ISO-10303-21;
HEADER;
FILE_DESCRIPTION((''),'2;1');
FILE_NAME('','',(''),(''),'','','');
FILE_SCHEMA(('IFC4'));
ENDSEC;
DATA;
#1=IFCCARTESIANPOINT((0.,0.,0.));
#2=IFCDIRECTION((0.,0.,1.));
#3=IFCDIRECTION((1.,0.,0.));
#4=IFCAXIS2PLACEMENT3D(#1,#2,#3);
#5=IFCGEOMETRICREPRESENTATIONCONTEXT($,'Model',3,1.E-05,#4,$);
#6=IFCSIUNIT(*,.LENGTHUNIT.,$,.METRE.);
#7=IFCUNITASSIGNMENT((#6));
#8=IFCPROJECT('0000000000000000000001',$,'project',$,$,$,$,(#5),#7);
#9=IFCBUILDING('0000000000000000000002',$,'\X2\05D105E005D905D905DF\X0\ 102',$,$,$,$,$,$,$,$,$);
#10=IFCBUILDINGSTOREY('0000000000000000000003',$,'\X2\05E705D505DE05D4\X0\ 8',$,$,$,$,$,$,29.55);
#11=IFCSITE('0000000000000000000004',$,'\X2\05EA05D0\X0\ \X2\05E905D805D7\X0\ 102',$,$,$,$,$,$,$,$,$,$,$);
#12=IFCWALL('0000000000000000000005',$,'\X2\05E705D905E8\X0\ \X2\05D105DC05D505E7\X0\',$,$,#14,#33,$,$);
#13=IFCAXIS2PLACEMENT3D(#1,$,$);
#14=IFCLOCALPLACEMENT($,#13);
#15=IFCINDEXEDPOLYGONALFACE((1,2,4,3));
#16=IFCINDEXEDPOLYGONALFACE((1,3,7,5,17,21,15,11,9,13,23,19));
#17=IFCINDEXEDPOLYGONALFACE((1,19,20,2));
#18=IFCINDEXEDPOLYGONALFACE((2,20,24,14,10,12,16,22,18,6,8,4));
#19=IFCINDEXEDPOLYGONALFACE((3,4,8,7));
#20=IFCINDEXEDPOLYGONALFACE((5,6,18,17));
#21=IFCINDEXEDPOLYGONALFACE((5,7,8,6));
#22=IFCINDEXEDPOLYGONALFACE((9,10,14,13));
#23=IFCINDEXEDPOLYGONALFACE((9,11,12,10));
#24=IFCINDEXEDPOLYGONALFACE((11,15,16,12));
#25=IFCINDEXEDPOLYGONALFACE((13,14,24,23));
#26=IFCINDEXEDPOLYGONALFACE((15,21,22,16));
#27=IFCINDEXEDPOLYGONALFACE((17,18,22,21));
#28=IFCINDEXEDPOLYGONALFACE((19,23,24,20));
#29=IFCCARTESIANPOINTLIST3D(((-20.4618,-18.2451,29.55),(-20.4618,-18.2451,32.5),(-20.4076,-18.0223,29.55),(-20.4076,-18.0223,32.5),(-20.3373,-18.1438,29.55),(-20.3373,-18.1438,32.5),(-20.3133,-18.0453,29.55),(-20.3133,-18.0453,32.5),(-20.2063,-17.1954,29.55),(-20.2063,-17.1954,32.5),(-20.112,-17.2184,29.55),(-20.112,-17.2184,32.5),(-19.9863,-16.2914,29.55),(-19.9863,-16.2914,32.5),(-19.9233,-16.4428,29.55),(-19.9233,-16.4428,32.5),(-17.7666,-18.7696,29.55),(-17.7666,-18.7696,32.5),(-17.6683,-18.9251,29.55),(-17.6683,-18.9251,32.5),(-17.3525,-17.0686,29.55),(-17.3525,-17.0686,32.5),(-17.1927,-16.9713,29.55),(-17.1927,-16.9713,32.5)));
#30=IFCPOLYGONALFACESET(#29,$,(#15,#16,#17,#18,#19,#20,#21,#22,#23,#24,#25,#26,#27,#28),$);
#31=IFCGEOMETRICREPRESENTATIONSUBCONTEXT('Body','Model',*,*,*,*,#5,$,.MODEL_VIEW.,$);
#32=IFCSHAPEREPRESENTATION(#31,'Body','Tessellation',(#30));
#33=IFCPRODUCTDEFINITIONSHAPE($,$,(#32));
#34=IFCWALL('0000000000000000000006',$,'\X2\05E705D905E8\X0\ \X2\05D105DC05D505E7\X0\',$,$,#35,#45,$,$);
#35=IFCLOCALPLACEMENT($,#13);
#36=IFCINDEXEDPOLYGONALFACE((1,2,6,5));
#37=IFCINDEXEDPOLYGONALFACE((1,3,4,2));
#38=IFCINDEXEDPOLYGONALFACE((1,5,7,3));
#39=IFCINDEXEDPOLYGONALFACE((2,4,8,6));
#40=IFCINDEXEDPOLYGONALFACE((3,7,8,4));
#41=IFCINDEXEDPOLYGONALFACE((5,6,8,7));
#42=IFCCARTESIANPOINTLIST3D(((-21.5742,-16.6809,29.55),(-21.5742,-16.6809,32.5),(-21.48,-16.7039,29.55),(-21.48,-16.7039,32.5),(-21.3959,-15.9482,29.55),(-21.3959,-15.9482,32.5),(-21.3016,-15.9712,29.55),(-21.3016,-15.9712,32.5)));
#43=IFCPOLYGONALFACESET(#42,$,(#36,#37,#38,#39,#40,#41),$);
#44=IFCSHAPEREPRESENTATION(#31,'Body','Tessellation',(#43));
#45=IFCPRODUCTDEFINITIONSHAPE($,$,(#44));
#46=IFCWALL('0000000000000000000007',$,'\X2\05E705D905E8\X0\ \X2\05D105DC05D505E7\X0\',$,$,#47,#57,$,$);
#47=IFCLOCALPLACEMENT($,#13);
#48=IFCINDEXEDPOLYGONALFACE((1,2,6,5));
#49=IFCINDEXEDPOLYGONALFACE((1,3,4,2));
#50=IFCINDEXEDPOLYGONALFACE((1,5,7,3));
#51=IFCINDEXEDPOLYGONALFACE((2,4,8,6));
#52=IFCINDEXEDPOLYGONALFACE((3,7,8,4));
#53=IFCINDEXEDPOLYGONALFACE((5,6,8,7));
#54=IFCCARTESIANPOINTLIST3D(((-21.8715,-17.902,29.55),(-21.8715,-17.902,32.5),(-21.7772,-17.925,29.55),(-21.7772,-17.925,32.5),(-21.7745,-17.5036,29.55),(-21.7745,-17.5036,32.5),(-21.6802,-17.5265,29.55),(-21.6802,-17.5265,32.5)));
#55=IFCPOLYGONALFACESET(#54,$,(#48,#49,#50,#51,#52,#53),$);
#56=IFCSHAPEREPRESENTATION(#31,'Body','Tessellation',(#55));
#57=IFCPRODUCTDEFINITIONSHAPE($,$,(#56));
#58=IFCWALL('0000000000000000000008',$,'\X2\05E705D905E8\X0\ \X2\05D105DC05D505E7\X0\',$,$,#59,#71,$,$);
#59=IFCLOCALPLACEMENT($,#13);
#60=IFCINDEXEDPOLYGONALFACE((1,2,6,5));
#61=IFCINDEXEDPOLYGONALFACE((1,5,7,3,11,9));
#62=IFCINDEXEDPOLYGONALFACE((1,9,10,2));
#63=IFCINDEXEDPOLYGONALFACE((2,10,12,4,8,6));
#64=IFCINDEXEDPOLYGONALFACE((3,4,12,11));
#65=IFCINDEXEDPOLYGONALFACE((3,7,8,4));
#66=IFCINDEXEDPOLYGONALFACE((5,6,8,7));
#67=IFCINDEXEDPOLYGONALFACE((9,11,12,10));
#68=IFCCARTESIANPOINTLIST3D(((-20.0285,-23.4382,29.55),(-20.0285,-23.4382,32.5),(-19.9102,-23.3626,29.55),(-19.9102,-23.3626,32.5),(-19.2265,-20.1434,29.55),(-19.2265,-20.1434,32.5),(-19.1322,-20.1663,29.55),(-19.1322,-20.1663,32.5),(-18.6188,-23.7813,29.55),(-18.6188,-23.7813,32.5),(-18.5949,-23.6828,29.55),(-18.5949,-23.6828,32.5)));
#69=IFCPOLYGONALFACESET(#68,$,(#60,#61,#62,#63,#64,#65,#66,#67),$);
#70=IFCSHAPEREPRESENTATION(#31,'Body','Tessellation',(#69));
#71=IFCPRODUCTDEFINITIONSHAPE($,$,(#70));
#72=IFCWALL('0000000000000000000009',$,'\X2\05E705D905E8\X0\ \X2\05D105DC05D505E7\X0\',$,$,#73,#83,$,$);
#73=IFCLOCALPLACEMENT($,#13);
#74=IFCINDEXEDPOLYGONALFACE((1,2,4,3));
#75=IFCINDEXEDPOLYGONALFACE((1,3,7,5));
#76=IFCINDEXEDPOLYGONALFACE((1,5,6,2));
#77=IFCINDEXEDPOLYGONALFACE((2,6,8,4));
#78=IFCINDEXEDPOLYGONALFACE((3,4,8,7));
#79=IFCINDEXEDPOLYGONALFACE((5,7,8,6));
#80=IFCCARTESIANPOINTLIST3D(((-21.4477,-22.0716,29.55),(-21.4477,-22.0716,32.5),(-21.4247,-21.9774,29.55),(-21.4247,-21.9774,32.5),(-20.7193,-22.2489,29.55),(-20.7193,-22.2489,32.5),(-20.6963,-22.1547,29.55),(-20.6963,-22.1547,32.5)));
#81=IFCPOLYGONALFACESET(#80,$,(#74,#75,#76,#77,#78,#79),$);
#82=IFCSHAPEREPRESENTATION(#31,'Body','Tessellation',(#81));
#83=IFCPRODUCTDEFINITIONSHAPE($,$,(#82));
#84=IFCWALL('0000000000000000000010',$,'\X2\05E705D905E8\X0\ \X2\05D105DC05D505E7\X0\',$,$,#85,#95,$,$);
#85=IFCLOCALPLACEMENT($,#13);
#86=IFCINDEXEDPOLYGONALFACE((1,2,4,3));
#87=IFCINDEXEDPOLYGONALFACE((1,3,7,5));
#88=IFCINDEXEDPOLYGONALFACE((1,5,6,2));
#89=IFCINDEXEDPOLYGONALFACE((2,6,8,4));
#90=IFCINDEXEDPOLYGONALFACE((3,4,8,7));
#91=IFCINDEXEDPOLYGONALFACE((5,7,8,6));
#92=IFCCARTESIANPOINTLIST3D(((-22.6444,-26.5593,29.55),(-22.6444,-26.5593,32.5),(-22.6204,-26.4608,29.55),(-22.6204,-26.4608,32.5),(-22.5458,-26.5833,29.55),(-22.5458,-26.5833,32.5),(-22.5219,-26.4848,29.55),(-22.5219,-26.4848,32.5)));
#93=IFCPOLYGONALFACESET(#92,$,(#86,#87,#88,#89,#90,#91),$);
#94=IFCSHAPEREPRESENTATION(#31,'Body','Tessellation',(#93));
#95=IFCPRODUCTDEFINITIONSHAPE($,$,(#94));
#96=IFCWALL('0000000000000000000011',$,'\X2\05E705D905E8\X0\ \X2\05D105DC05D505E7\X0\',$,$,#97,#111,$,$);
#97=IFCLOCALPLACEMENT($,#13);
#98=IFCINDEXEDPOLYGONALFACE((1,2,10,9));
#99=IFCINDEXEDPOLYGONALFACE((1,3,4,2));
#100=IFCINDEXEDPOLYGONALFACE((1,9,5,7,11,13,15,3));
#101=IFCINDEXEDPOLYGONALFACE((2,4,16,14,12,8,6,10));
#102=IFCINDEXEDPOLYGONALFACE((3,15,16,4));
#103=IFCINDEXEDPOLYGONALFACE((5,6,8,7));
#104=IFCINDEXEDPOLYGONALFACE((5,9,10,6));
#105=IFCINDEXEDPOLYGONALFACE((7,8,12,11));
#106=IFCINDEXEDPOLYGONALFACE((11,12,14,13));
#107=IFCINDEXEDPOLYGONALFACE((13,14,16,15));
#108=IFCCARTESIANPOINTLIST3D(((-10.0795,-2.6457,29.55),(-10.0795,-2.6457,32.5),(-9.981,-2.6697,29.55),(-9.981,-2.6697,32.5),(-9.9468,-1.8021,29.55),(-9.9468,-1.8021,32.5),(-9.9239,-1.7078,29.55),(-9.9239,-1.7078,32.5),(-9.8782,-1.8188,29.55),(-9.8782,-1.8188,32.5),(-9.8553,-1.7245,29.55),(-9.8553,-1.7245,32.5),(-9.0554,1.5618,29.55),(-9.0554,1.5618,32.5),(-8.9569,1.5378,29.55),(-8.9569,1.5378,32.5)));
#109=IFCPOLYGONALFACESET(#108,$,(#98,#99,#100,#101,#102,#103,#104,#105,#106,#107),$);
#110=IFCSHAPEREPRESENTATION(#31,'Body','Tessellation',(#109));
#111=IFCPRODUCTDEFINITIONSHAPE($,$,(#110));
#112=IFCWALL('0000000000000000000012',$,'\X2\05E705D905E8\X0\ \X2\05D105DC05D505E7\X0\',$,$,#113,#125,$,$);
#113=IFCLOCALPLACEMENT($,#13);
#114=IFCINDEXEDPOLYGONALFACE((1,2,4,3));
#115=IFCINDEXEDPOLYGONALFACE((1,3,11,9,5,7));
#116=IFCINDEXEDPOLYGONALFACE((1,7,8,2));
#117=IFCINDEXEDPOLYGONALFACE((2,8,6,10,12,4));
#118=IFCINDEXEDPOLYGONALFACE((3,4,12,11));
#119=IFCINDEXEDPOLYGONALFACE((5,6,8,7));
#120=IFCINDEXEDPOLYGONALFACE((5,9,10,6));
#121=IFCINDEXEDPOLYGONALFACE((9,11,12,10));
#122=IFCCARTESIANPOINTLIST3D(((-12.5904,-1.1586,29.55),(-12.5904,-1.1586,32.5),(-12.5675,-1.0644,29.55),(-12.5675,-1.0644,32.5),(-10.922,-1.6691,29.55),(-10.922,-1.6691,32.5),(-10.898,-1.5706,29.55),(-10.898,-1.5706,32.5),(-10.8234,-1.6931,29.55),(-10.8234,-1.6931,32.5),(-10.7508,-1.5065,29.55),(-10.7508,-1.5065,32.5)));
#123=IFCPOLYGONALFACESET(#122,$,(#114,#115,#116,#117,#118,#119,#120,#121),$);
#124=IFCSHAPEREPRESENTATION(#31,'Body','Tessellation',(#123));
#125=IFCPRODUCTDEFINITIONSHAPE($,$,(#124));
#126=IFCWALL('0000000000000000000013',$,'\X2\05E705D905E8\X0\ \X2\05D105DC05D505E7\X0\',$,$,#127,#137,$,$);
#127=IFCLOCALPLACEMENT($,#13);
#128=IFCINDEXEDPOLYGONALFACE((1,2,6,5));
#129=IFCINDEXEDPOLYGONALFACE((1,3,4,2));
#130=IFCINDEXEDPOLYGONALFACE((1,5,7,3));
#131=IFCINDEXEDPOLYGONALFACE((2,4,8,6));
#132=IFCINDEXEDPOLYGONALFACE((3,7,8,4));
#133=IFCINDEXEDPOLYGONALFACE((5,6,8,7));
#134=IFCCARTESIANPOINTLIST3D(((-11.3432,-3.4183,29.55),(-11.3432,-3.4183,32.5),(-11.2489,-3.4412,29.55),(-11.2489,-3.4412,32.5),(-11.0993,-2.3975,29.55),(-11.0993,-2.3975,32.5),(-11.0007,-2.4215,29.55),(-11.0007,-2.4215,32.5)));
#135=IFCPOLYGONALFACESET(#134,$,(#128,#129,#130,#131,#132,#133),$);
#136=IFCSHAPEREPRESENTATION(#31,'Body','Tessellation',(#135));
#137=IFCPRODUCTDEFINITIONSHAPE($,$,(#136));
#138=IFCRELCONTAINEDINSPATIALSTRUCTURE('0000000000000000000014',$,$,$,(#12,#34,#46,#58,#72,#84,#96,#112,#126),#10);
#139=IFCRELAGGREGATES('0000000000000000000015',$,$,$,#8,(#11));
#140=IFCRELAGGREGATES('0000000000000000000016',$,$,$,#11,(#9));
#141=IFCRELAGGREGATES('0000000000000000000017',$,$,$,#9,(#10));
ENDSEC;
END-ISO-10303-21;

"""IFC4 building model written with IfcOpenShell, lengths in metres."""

from ifc_helpers import new_model, si_unit, frame, origin_with_axes, context, subcontext, project, spatial, polyline, outline, extrude, element, save


model = new_model("IFC4")

# Units and contexts
model_context = context("Model", 3, precision=1e-05, world=origin_with_axes())
body_context = subcontext(model_context, "Body", "Model", "MODEL_VIEW")
ifc_project = project(units=[si_unit("LENGTHUNIT", "METRE")], contexts=[model_context])

# Site, building, storey
site = spatial("IfcSite", under=ifc_project, Name="תא שטח 102")
building = spatial("IfcBuilding", under=site, Name="בניין 102")
storey = spatial("IfcBuildingStorey", under=building, Name="קומה 8", Elevation=29.55)

# Walls
element("IfcWall", 1, inside=storey, Name="קיר בלוק", context=body_context, shape_type="SweptSolid", body=[
    extrude(outline(polyline([(-19.9233, -16.4428), (-17.3525, -17.0686), (-17.7666, -18.7696), (-20.3373, -18.1438), (-20.3133, -18.0453), (-20.4076, -18.0223), (-20.4618, -18.2451), (-17.6683, -18.9251), (-17.1927, -16.9713), (-19.9863, -16.2914), (-20.2063, -17.1954), (-20.112, -17.2184), (-19.9233, -16.4428)])), frame((0.0, 0.0, 29.55)), (0.0, 0.0, 1.0), 2.95),
])
element("IfcWall", 2, inside=storey, Name="קיר בלוק", context=body_context, shape_type="SweptSolid", body=[
    extrude(outline(polyline([(-21.3959, -15.9482), (-21.5742, -16.6809), (-21.48, -16.7039), (-21.3016, -15.9712), (-21.3959, -15.9482)])), frame((0.0, 0.0, 29.55)), (0.0, 0.0, 1.0), 2.95),
])
element("IfcWall", 3, inside=storey, Name="קיר בלוק", context=body_context, shape_type="SweptSolid", body=[
    extrude(outline(polyline([(-21.8715, -17.902), (-21.7772, -17.925), (-21.6802, -17.5265), (-21.7745, -17.5036), (-21.8715, -17.902)])), frame((0.0, 0.0, 29.55)), (0.0, 0.0, 1.0), 2.95),
])
element("IfcWall", 4, inside=storey, Name="קיר בלוק", context=body_context, shape_type="SweptSolid", body=[
    extrude(outline(polyline([(-18.5949, -23.6828), (-19.9102, -23.3626), (-19.1322, -20.1663), (-19.2265, -20.1434), (-20.0285, -23.4382), (-18.6188, -23.7813), (-18.5949, -23.6828)])), frame((0.0, 0.0, 29.55)), (0.0, 0.0, 1.0), 2.95),
])
element("IfcWall", 5, inside=storey, Name="קיר בלוק", context=body_context, shape_type="SweptSolid", body=[
    extrude(outline(polyline([(-21.4477, -22.0716), (-20.7193, -22.2489), (-20.6963, -22.1547), (-21.4247, -21.9774), (-21.4477, -22.0716)])), frame((0.0, 0.0, 29.55)), (0.0, 0.0, 1.0), 2.95),
])
element("IfcWall", 6, inside=storey, Name="קיר בלוק", context=body_context, shape_type="SweptSolid", body=[
    extrude(outline(polyline([(-22.6444, -26.5593), (-22.5458, -26.5833), (-22.5219, -26.4848), (-22.6204, -26.4608), (-22.6444, -26.5593)])), frame((0.0, 0.0, 29.55)), (0.0, 0.0, 1.0), 2.95),
])
element("IfcWall", 7, inside=storey, Name="קיר בלוק", context=body_context, shape_type="SweptSolid", body=[
    extrude(outline(polyline([(-10.0795, -2.6457), (-9.981, -2.6697), (-8.9569, 1.5378), (-9.0554, 1.5618), (-9.8553, -1.7245), (-9.9239, -1.7078), (-9.9468, -1.8021), (-9.8782, -1.8188), (-10.0795, -2.6457)])), frame((0.0, 0.0, 29.55)), (0.0, 0.0, 1.0), 2.95),
])
element("IfcWall", 8, inside=storey, Name="קיר בלוק", context=body_context, shape_type="SweptSolid", body=[
    extrude(outline(polyline([(-10.922, -1.6691), (-10.8234, -1.6931), (-10.7508, -1.5065), (-12.5675, -1.0644), (-12.5904, -1.1586), (-10.898, -1.5706), (-10.922, -1.6691)])), frame((0.0, 0.0, 29.55)), (0.0, 0.0, 1.0), 2.95),
])
element("IfcWall", 9, inside=storey, Name="קיר בלוק", context=body_context, shape_type="SweptSolid", body=[
    extrude(outline(polyline([(-11.2489, -3.4412), (-11.0007, -2.4215), (-11.0993, -2.3975), (-11.3432, -3.4183), (-11.2489, -3.4412)])), frame((0.0, 0.0, 29.55)), (0.0, 0.0, 1.0), 2.95),
])

save(model, "model.ifc")
